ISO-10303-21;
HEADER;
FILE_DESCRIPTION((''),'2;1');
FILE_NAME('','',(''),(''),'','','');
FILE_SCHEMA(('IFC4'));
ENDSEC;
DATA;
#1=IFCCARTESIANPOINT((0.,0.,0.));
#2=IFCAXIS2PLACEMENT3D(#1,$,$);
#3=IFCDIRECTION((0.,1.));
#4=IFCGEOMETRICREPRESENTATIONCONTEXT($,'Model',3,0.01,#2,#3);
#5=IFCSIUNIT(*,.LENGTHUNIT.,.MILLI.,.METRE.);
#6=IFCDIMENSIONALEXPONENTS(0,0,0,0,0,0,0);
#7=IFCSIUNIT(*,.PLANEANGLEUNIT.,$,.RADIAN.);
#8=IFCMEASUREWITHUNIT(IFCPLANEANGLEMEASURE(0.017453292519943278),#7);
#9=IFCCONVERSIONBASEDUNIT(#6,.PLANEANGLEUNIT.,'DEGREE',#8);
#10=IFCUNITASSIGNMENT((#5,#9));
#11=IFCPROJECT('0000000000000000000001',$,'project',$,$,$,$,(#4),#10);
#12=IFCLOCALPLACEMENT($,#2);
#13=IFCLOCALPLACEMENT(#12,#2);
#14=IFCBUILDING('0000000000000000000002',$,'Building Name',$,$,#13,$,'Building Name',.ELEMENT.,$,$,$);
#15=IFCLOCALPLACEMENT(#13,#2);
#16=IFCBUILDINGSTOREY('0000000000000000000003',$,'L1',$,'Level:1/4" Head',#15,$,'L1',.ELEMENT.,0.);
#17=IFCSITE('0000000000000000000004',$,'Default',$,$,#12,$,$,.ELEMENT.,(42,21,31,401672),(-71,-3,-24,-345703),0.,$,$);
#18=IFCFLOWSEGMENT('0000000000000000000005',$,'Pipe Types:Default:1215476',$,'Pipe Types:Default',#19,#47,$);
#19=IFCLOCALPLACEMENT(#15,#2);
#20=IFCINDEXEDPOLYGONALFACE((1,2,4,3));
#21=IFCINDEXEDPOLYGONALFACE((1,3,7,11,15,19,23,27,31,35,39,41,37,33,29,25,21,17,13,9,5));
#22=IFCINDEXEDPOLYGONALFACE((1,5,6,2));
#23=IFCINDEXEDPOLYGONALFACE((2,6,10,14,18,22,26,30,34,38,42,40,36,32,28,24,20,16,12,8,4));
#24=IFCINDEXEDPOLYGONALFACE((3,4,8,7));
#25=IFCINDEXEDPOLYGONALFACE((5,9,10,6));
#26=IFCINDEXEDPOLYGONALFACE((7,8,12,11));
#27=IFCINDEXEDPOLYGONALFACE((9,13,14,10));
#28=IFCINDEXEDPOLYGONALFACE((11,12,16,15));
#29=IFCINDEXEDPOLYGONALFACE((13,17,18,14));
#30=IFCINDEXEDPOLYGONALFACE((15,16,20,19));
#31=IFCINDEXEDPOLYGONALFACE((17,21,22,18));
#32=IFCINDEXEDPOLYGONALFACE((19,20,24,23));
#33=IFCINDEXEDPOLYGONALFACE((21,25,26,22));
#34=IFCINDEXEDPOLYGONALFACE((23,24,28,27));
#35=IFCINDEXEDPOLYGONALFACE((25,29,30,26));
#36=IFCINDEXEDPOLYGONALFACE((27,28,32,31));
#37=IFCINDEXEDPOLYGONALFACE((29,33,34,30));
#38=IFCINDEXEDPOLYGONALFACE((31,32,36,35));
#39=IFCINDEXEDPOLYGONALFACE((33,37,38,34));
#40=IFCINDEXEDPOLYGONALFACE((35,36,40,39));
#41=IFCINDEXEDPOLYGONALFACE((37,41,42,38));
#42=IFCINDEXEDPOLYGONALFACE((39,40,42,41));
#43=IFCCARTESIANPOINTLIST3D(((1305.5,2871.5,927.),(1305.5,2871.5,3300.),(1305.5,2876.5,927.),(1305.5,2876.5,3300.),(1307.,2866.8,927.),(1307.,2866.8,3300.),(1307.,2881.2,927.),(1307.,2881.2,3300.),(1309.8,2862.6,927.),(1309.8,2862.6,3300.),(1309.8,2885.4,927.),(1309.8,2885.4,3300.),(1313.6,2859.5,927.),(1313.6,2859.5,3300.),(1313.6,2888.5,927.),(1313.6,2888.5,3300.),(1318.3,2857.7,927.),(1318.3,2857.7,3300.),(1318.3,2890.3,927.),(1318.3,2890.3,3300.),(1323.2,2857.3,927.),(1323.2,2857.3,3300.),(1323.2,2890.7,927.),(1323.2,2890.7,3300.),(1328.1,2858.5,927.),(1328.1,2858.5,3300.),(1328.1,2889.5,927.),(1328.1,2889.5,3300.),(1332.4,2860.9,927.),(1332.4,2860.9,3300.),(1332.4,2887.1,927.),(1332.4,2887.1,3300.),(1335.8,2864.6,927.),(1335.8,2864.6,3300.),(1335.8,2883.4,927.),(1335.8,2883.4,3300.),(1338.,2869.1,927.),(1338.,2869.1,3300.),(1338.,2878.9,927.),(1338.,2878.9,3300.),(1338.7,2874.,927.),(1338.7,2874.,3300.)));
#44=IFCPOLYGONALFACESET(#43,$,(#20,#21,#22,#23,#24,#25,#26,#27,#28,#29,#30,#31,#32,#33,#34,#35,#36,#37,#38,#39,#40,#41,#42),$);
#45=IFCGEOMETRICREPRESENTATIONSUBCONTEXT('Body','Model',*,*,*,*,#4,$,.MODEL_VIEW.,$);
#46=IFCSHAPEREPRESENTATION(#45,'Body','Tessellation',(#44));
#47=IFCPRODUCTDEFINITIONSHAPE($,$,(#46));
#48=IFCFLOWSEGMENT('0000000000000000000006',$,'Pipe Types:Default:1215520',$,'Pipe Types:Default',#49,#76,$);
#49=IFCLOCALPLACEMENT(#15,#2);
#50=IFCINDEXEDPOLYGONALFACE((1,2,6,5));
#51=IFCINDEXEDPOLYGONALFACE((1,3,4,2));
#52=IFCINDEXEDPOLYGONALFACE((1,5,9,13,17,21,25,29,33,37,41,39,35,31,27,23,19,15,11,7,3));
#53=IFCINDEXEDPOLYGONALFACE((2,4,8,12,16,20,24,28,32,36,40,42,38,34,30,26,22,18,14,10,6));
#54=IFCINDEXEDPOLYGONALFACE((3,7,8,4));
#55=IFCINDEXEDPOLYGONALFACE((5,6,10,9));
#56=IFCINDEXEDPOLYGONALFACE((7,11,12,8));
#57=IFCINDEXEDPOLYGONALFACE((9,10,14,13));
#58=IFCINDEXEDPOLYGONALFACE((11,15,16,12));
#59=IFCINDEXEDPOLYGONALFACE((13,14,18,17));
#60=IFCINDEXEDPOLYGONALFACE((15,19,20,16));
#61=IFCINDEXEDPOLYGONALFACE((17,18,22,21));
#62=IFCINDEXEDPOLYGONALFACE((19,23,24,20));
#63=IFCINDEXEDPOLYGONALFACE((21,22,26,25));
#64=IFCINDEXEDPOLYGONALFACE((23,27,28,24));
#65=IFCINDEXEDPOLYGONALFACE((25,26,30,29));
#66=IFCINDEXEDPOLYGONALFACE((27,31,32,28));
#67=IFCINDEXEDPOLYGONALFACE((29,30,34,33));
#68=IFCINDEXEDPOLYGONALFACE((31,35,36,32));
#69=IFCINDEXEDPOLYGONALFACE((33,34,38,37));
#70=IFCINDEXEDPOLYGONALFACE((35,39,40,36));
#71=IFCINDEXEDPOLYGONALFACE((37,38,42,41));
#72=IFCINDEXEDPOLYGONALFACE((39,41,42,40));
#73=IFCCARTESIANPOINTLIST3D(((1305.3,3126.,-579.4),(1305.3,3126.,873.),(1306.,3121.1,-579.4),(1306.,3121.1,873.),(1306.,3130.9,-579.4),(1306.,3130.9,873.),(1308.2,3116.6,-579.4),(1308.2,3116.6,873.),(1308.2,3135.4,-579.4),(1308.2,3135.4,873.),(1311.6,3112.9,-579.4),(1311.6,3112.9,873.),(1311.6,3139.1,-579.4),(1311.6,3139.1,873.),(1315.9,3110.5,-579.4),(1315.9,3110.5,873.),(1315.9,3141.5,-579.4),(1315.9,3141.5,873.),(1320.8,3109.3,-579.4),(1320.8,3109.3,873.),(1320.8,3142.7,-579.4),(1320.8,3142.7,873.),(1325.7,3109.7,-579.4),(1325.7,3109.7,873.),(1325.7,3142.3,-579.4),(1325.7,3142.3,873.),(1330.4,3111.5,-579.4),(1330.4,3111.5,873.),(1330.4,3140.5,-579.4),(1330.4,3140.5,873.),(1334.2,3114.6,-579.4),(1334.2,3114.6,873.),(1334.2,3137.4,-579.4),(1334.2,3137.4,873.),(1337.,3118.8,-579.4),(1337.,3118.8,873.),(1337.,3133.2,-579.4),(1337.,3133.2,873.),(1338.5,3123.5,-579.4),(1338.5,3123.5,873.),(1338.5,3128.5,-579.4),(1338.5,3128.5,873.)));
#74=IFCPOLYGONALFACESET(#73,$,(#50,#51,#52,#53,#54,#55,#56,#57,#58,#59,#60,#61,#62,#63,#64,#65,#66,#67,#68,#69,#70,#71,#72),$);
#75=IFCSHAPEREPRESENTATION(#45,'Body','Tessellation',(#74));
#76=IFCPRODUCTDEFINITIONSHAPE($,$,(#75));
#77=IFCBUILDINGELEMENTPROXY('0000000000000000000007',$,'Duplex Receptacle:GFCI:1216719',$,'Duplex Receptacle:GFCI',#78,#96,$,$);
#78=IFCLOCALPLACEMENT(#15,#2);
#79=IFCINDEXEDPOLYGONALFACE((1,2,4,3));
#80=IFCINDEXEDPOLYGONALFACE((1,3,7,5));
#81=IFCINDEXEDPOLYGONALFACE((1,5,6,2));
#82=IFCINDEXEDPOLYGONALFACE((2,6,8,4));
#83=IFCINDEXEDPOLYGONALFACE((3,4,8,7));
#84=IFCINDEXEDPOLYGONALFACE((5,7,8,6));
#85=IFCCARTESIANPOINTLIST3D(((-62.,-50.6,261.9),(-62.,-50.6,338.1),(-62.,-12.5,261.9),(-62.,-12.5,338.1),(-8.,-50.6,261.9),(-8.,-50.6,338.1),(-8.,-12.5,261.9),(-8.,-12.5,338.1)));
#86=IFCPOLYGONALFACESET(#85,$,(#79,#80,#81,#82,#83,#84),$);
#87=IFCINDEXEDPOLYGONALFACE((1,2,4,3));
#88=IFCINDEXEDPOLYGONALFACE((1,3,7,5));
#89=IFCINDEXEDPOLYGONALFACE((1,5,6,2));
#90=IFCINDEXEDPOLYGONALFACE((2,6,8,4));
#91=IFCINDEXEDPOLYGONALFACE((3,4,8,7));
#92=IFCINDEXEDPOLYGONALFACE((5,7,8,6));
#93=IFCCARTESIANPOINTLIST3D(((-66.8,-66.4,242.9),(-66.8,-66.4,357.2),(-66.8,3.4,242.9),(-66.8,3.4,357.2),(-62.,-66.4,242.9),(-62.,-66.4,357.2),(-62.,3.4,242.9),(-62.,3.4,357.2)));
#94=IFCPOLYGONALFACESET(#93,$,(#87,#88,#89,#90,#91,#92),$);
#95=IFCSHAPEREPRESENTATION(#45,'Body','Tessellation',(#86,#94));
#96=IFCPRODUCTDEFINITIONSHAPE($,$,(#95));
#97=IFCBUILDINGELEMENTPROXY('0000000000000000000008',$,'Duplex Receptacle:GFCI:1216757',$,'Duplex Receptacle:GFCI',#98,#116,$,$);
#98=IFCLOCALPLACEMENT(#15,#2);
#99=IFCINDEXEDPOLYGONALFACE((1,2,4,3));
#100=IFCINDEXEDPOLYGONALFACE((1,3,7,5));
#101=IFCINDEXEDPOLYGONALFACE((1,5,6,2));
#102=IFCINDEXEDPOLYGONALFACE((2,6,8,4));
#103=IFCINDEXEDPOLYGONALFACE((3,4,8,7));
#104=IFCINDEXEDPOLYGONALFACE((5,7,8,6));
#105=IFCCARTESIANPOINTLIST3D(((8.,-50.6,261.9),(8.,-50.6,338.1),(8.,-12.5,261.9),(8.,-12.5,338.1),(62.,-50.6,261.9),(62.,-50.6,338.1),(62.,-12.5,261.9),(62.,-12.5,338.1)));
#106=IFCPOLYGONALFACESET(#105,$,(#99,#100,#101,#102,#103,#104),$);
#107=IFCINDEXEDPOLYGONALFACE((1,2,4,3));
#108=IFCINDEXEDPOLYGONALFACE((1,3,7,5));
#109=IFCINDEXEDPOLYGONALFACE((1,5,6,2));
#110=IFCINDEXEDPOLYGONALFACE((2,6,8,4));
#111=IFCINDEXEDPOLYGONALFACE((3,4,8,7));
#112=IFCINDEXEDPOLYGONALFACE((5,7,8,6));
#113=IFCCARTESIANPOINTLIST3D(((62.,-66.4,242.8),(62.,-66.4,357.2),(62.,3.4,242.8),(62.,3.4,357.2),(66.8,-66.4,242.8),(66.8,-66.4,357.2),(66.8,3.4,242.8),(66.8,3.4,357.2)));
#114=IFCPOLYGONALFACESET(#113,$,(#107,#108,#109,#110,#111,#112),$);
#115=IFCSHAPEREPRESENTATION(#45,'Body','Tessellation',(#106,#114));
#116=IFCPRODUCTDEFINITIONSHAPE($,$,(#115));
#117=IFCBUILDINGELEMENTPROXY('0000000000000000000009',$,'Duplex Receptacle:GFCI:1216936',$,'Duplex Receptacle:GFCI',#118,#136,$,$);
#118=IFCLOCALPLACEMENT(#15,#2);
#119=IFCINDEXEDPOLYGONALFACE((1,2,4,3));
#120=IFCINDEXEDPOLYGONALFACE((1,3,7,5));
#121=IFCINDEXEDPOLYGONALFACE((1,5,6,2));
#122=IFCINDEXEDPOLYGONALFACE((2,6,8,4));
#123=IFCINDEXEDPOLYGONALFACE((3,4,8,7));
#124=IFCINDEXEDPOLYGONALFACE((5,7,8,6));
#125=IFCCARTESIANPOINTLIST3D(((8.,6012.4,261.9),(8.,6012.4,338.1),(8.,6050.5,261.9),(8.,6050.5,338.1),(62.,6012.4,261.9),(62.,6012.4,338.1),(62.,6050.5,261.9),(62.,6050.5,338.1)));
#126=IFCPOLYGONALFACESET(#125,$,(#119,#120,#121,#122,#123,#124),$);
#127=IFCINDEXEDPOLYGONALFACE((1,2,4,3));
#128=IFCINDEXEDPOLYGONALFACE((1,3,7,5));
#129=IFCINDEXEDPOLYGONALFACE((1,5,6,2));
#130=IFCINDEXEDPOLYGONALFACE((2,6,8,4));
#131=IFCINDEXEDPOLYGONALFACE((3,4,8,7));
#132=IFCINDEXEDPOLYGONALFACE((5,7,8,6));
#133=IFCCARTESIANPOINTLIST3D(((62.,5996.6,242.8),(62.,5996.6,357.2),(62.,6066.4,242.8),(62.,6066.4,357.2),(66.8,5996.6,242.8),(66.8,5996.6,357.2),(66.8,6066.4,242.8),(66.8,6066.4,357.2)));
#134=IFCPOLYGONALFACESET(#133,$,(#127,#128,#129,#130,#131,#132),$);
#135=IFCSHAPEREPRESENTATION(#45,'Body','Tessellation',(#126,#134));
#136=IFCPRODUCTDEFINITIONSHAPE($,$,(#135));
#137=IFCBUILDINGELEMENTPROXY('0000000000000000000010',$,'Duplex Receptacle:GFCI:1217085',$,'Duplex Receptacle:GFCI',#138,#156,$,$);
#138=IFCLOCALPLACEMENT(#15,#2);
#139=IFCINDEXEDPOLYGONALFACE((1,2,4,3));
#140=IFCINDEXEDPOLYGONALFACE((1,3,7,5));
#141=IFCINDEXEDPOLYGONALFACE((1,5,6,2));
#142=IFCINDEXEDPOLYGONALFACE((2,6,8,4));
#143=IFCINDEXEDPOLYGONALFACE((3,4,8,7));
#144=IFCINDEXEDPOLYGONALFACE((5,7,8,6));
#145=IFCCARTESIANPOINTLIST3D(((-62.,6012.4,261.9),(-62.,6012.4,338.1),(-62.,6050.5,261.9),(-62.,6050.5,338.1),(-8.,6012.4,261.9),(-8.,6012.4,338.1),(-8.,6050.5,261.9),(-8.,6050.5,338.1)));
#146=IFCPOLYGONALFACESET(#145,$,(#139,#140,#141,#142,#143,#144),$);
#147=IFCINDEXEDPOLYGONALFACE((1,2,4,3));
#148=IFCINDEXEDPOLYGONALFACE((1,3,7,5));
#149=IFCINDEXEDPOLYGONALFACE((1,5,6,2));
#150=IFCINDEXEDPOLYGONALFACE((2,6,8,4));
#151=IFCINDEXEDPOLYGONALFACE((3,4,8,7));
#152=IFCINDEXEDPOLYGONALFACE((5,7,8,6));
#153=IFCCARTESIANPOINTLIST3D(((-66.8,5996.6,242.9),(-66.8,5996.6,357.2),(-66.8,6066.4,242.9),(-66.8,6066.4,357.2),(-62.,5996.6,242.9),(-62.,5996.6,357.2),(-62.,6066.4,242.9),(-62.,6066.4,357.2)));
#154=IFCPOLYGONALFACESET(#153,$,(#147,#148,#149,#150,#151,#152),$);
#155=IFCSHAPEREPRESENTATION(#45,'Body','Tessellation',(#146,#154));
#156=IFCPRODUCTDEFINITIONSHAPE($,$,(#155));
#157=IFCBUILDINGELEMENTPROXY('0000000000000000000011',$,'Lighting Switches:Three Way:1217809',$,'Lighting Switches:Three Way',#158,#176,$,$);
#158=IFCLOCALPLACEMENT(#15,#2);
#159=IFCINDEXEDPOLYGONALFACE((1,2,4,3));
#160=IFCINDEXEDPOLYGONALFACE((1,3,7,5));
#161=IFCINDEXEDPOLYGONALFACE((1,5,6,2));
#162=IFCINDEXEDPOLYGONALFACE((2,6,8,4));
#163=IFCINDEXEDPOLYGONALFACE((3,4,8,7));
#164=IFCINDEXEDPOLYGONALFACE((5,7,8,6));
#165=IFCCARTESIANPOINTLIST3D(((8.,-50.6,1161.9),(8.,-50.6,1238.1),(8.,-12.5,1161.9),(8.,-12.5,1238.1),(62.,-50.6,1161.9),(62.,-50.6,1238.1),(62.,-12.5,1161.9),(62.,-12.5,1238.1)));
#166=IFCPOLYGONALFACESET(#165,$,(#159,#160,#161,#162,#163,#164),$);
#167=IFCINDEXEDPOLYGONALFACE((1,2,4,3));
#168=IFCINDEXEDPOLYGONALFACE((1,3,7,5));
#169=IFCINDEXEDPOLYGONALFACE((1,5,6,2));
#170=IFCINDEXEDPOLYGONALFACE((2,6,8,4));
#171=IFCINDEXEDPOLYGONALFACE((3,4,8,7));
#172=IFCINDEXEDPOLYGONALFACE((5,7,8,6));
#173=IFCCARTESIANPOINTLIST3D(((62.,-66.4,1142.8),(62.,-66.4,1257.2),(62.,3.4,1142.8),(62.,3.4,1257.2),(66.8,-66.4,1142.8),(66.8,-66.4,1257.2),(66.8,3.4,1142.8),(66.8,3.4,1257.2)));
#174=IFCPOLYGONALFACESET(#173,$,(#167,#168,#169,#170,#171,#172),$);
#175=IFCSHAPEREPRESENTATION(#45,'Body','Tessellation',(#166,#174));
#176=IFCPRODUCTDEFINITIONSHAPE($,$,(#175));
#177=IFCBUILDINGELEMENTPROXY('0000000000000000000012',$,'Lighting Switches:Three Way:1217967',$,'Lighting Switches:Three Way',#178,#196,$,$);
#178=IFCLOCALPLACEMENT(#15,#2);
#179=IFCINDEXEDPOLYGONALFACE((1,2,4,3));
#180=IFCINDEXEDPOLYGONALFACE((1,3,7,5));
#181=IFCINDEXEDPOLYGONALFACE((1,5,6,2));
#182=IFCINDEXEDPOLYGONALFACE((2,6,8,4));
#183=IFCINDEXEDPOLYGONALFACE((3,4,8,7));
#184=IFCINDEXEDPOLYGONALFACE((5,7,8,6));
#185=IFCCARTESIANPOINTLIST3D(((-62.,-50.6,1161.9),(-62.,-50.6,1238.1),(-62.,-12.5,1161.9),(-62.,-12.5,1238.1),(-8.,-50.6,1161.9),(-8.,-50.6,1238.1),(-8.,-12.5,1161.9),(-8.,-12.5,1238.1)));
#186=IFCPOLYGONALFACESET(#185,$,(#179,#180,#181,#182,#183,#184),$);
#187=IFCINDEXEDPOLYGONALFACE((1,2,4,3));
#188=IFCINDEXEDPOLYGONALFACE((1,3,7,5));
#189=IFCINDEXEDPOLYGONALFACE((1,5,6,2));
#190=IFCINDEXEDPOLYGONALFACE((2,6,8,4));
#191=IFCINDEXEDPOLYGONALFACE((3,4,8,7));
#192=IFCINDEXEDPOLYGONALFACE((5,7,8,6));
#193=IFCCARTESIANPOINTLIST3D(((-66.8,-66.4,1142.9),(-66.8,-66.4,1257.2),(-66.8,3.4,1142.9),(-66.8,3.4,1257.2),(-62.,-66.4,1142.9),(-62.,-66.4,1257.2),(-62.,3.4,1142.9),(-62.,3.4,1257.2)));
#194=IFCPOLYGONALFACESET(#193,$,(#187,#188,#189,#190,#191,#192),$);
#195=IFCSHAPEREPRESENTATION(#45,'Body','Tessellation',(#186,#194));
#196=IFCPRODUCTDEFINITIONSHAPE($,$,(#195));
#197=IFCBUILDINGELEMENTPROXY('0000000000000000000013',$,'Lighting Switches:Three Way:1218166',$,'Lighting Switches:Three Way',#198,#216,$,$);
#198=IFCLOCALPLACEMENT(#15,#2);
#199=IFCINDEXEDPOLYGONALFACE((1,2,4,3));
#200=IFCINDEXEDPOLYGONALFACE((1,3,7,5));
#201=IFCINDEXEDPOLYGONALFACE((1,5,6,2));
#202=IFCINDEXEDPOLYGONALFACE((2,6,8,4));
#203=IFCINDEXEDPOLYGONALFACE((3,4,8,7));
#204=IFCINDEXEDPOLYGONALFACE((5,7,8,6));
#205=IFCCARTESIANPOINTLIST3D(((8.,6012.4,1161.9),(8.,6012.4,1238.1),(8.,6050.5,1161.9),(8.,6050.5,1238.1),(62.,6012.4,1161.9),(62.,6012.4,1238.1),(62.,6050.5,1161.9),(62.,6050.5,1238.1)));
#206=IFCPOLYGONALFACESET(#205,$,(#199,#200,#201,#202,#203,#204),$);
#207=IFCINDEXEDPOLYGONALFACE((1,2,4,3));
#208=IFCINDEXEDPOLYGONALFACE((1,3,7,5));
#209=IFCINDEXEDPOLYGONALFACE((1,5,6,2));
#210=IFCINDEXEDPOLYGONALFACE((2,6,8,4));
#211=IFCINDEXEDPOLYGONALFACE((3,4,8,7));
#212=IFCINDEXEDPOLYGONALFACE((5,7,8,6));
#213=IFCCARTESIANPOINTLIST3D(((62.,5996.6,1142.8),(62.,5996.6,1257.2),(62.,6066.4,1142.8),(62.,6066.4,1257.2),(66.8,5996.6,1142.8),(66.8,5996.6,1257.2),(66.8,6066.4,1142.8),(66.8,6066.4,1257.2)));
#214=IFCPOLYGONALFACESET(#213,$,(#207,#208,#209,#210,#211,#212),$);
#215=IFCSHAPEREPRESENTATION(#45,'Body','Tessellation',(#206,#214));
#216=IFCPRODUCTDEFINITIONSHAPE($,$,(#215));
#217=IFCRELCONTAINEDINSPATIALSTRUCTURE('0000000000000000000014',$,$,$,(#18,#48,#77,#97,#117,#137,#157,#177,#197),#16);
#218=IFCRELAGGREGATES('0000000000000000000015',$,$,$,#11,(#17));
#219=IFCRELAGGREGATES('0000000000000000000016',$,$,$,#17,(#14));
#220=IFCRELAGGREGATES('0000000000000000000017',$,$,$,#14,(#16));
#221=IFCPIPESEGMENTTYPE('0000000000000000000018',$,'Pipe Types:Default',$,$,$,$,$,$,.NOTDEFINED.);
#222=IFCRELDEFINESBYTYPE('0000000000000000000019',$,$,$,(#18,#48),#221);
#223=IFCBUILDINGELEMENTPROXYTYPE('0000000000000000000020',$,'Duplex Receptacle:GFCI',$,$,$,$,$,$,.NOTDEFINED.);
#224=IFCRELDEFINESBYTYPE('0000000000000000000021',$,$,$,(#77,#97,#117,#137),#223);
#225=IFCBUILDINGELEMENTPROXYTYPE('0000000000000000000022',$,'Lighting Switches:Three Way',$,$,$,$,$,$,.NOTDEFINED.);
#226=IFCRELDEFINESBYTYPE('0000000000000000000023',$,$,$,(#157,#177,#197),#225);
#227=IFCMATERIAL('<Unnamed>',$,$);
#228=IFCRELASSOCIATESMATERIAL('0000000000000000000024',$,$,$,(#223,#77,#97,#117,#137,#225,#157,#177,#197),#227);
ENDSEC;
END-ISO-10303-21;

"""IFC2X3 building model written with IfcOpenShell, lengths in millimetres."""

from ifc_helpers import new_model, entity, si_unit, converted_unit, direction, frame, frame_2d, origin, origin_2d_with_axis, place, context, subcontext, project, spatial, rectangle, circle, extrude, source, transform, mapped, material, type_object, type_shapes, element, save


model = new_model("IFC2X3")

# Units and contexts
model_context = context("Model", 3, precision=0.01, world=origin(), true_north=direction((0.0, 1.0)))
body_context = subcontext(model_context, "Body", "Model", "MODEL_VIEW")
ifc_project = project(units=[si_unit("LENGTHUNIT", "METRE", prefix="MILLI"), converted_unit("PLANEANGLEUNIT", "DEGREE", entity("IfcPlaneAngleMeasure", 0.017453292519943278), si_unit("PLANEANGLEUNIT", "RADIAN"), dimensions=[0, 0, 0, 0, 0, 0, 0])], contexts=[model_context])

# Site, building, storey
site_placement = place(None, origin())
site = spatial("IfcSite", under=ifc_project, at=site_placement, Name="Default", CompositionType="ELEMENT", RefLatitude=(42, 21, 31, 401672), RefLongitude=(-71, -3, -24, -345703), RefElevation=0.0)
building_placement = place(site_placement, origin())
building = spatial("IfcBuilding", under=site, at=building_placement, Name="Building Name", LongName="Building Name", CompositionType="ELEMENT")
storey_placement = place(building_placement, origin())
storey = spatial("IfcBuildingStorey", under=building, at=storey_placement, Name="L1", ObjectType="Level:1/4\" Head", LongName="L1", CompositionType="ELEMENT", Elevation=0.0)

# Flow segments
pipe_segment_type = type_object("IfcPipeSegmentType", Name="Pipe Types:Default", PredefinedType="NOTDEFINED")
flow_segment_1_placement = place(storey_placement, origin())
element("IfcFlowSegment", 1, at=flow_segment_1_placement, inside=storey, type_object=pipe_segment_type, Name="Pipe Types:Default:1215476", ObjectType="Pipe Types:Default", context=body_context, shape_type="SweptSolid", body=[
    extrude(circle(Radius=16.7, at=origin_2d_with_axis()), frame((1322.0, 2874.0, 927.0)), (0.0, 0.0, 1.0), 2373.0),
])
flow_segment_2_placement = place(storey_placement, origin())
element("IfcFlowSegment", 2, at=flow_segment_2_placement, inside=storey, type_object=pipe_segment_type, Name="Pipe Types:Default:1215520", ObjectType="Pipe Types:Default", context=body_context, shape_type="SweptSolid", body=[
    extrude(circle(Radius=16.7, at=origin_2d_with_axis()), frame((1322.0, 3126.0, -579.4), z_axis=(0.0, 0.0, 1.0), x_axis=(-1.0, 0.0, 0.0)), (0.0, 0.0, 1.0), 1452.4),
])

# Building element proxies
ifc_material = material(Name="<Unnamed>")
building_element_proxy_type_1 = type_object("IfcBuildingElementProxyType", Name="Duplex Receptacle:GFCI", PredefinedType="NOTDEFINED", material=ifc_material)
shared_shape_1 = source(origin(), body_context, "Body", "SweptSolid", [
    extrude(rectangle(XDim=38.1, YDim=76.2, at=origin_2d_with_axis()), frame((0.0, 0.0, -54.0), z_axis=(0.0, 0.0, 1.0), x_axis=(-1.0, 0.0, 0.0)), (0.0, 0.0, 1.0), 54.0),
    extrude(rectangle(XDim=69.8, YDim=114.3, at=frame_2d((0.0, 0.0), x_axis=(1.0, 0.0))), frame((0.0, 0.0, 0.0), z_axis=(0.0, 0.0, 1.0), x_axis=(-1.0, 0.0, 0.0)), (0.0, 0.0, 1.0), 4.8),
])
type_shapes(building_element_proxy_type_1, [shared_shape_1])
for number, where, z_axis, x_axis, name in (
    (3, (-62.0, -31.5, 300.0), (-1.0, 0.0, 0.0), (0.0, -1.0, 0.0), "Duplex Receptacle:GFCI:1216719"),
    (4, (62.0, -31.5, 300.0), (1.0, 0.0, 0.0), (0.0, 1.0, 0.0), "Duplex Receptacle:GFCI:1216757"),
    (5, (62.0, 6031.5, 300.0), (1.0, 0.0, 0.0), (0.0, 1.0, 0.0), "Duplex Receptacle:GFCI:1216936"),
    (6, (-62.0, 6031.5, 300.0), (-1.0, 0.0, 0.0), (0.0, -1.0, 0.0), "Duplex Receptacle:GFCI:1217085"),
):
    element("IfcBuildingElementProxy", number, at=place(storey_placement, frame(where, z_axis=z_axis, x_axis=x_axis)), inside=storey, type_object=building_element_proxy_type_1, material=ifc_material, Name=name, ObjectType="Duplex Receptacle:GFCI", context=body_context, shape_type="MappedRepresentation", body=[
        mapped(shared_shape_1, transform((0.0, 0.0, 0.0), scale=1.0)),
    ])
building_element_proxy_type_2 = type_object("IfcBuildingElementProxyType", Name="Lighting Switches:Three Way", PredefinedType="NOTDEFINED", material=ifc_material)
shared_shape_2 = source(origin(), body_context, "Body", "SweptSolid", [
    extrude(rectangle(XDim=38.1, YDim=76.2, at=origin_2d_with_axis()), frame((0.0, 0.0, -54.0), z_axis=(0.0, 0.0, 1.0), x_axis=(-1.0, 0.0, 0.0)), (0.0, 0.0, 1.0), 54.0),
    extrude(rectangle(XDim=69.8, YDim=114.3, at=frame_2d((0.0, 0.0), x_axis=(1.0, 0.0))), frame((0.0, 0.0, 0.0), z_axis=(0.0, 0.0, 1.0), x_axis=(-1.0, 0.0, 0.0)), (0.0, 0.0, 1.0), 4.8),
])
type_shapes(building_element_proxy_type_2, [shared_shape_2])
for number, where, z_axis, x_axis, name in (
    (7, (62.0, -31.5, 1200.0), (1.0, 0.0, 0.0), (0.0, 1.0, 0.0), "Lighting Switches:Three Way:1217809"),
    (8, (-62.0, -31.5, 1200.0), (-1.0, 0.0, 0.0), (0.0, -1.0, 0.0), "Lighting Switches:Three Way:1217967"),
    (9, (62.0, 6031.5, 1200.0), (1.0, 0.0, 0.0), (0.0, 1.0, 0.0), "Lighting Switches:Three Way:1218166"),
):
    element("IfcBuildingElementProxy", number, at=place(storey_placement, frame(where, z_axis=z_axis, x_axis=x_axis)), inside=storey, type_object=building_element_proxy_type_2, material=ifc_material, Name=name, ObjectType="Lighting Switches:Three Way", context=body_context, shape_type="MappedRepresentation", body=[
        mapped(shared_shape_2, transform((0.0, 0.0, 0.0), scale=1.0)),
    ])

save(model, "model.ifc")
